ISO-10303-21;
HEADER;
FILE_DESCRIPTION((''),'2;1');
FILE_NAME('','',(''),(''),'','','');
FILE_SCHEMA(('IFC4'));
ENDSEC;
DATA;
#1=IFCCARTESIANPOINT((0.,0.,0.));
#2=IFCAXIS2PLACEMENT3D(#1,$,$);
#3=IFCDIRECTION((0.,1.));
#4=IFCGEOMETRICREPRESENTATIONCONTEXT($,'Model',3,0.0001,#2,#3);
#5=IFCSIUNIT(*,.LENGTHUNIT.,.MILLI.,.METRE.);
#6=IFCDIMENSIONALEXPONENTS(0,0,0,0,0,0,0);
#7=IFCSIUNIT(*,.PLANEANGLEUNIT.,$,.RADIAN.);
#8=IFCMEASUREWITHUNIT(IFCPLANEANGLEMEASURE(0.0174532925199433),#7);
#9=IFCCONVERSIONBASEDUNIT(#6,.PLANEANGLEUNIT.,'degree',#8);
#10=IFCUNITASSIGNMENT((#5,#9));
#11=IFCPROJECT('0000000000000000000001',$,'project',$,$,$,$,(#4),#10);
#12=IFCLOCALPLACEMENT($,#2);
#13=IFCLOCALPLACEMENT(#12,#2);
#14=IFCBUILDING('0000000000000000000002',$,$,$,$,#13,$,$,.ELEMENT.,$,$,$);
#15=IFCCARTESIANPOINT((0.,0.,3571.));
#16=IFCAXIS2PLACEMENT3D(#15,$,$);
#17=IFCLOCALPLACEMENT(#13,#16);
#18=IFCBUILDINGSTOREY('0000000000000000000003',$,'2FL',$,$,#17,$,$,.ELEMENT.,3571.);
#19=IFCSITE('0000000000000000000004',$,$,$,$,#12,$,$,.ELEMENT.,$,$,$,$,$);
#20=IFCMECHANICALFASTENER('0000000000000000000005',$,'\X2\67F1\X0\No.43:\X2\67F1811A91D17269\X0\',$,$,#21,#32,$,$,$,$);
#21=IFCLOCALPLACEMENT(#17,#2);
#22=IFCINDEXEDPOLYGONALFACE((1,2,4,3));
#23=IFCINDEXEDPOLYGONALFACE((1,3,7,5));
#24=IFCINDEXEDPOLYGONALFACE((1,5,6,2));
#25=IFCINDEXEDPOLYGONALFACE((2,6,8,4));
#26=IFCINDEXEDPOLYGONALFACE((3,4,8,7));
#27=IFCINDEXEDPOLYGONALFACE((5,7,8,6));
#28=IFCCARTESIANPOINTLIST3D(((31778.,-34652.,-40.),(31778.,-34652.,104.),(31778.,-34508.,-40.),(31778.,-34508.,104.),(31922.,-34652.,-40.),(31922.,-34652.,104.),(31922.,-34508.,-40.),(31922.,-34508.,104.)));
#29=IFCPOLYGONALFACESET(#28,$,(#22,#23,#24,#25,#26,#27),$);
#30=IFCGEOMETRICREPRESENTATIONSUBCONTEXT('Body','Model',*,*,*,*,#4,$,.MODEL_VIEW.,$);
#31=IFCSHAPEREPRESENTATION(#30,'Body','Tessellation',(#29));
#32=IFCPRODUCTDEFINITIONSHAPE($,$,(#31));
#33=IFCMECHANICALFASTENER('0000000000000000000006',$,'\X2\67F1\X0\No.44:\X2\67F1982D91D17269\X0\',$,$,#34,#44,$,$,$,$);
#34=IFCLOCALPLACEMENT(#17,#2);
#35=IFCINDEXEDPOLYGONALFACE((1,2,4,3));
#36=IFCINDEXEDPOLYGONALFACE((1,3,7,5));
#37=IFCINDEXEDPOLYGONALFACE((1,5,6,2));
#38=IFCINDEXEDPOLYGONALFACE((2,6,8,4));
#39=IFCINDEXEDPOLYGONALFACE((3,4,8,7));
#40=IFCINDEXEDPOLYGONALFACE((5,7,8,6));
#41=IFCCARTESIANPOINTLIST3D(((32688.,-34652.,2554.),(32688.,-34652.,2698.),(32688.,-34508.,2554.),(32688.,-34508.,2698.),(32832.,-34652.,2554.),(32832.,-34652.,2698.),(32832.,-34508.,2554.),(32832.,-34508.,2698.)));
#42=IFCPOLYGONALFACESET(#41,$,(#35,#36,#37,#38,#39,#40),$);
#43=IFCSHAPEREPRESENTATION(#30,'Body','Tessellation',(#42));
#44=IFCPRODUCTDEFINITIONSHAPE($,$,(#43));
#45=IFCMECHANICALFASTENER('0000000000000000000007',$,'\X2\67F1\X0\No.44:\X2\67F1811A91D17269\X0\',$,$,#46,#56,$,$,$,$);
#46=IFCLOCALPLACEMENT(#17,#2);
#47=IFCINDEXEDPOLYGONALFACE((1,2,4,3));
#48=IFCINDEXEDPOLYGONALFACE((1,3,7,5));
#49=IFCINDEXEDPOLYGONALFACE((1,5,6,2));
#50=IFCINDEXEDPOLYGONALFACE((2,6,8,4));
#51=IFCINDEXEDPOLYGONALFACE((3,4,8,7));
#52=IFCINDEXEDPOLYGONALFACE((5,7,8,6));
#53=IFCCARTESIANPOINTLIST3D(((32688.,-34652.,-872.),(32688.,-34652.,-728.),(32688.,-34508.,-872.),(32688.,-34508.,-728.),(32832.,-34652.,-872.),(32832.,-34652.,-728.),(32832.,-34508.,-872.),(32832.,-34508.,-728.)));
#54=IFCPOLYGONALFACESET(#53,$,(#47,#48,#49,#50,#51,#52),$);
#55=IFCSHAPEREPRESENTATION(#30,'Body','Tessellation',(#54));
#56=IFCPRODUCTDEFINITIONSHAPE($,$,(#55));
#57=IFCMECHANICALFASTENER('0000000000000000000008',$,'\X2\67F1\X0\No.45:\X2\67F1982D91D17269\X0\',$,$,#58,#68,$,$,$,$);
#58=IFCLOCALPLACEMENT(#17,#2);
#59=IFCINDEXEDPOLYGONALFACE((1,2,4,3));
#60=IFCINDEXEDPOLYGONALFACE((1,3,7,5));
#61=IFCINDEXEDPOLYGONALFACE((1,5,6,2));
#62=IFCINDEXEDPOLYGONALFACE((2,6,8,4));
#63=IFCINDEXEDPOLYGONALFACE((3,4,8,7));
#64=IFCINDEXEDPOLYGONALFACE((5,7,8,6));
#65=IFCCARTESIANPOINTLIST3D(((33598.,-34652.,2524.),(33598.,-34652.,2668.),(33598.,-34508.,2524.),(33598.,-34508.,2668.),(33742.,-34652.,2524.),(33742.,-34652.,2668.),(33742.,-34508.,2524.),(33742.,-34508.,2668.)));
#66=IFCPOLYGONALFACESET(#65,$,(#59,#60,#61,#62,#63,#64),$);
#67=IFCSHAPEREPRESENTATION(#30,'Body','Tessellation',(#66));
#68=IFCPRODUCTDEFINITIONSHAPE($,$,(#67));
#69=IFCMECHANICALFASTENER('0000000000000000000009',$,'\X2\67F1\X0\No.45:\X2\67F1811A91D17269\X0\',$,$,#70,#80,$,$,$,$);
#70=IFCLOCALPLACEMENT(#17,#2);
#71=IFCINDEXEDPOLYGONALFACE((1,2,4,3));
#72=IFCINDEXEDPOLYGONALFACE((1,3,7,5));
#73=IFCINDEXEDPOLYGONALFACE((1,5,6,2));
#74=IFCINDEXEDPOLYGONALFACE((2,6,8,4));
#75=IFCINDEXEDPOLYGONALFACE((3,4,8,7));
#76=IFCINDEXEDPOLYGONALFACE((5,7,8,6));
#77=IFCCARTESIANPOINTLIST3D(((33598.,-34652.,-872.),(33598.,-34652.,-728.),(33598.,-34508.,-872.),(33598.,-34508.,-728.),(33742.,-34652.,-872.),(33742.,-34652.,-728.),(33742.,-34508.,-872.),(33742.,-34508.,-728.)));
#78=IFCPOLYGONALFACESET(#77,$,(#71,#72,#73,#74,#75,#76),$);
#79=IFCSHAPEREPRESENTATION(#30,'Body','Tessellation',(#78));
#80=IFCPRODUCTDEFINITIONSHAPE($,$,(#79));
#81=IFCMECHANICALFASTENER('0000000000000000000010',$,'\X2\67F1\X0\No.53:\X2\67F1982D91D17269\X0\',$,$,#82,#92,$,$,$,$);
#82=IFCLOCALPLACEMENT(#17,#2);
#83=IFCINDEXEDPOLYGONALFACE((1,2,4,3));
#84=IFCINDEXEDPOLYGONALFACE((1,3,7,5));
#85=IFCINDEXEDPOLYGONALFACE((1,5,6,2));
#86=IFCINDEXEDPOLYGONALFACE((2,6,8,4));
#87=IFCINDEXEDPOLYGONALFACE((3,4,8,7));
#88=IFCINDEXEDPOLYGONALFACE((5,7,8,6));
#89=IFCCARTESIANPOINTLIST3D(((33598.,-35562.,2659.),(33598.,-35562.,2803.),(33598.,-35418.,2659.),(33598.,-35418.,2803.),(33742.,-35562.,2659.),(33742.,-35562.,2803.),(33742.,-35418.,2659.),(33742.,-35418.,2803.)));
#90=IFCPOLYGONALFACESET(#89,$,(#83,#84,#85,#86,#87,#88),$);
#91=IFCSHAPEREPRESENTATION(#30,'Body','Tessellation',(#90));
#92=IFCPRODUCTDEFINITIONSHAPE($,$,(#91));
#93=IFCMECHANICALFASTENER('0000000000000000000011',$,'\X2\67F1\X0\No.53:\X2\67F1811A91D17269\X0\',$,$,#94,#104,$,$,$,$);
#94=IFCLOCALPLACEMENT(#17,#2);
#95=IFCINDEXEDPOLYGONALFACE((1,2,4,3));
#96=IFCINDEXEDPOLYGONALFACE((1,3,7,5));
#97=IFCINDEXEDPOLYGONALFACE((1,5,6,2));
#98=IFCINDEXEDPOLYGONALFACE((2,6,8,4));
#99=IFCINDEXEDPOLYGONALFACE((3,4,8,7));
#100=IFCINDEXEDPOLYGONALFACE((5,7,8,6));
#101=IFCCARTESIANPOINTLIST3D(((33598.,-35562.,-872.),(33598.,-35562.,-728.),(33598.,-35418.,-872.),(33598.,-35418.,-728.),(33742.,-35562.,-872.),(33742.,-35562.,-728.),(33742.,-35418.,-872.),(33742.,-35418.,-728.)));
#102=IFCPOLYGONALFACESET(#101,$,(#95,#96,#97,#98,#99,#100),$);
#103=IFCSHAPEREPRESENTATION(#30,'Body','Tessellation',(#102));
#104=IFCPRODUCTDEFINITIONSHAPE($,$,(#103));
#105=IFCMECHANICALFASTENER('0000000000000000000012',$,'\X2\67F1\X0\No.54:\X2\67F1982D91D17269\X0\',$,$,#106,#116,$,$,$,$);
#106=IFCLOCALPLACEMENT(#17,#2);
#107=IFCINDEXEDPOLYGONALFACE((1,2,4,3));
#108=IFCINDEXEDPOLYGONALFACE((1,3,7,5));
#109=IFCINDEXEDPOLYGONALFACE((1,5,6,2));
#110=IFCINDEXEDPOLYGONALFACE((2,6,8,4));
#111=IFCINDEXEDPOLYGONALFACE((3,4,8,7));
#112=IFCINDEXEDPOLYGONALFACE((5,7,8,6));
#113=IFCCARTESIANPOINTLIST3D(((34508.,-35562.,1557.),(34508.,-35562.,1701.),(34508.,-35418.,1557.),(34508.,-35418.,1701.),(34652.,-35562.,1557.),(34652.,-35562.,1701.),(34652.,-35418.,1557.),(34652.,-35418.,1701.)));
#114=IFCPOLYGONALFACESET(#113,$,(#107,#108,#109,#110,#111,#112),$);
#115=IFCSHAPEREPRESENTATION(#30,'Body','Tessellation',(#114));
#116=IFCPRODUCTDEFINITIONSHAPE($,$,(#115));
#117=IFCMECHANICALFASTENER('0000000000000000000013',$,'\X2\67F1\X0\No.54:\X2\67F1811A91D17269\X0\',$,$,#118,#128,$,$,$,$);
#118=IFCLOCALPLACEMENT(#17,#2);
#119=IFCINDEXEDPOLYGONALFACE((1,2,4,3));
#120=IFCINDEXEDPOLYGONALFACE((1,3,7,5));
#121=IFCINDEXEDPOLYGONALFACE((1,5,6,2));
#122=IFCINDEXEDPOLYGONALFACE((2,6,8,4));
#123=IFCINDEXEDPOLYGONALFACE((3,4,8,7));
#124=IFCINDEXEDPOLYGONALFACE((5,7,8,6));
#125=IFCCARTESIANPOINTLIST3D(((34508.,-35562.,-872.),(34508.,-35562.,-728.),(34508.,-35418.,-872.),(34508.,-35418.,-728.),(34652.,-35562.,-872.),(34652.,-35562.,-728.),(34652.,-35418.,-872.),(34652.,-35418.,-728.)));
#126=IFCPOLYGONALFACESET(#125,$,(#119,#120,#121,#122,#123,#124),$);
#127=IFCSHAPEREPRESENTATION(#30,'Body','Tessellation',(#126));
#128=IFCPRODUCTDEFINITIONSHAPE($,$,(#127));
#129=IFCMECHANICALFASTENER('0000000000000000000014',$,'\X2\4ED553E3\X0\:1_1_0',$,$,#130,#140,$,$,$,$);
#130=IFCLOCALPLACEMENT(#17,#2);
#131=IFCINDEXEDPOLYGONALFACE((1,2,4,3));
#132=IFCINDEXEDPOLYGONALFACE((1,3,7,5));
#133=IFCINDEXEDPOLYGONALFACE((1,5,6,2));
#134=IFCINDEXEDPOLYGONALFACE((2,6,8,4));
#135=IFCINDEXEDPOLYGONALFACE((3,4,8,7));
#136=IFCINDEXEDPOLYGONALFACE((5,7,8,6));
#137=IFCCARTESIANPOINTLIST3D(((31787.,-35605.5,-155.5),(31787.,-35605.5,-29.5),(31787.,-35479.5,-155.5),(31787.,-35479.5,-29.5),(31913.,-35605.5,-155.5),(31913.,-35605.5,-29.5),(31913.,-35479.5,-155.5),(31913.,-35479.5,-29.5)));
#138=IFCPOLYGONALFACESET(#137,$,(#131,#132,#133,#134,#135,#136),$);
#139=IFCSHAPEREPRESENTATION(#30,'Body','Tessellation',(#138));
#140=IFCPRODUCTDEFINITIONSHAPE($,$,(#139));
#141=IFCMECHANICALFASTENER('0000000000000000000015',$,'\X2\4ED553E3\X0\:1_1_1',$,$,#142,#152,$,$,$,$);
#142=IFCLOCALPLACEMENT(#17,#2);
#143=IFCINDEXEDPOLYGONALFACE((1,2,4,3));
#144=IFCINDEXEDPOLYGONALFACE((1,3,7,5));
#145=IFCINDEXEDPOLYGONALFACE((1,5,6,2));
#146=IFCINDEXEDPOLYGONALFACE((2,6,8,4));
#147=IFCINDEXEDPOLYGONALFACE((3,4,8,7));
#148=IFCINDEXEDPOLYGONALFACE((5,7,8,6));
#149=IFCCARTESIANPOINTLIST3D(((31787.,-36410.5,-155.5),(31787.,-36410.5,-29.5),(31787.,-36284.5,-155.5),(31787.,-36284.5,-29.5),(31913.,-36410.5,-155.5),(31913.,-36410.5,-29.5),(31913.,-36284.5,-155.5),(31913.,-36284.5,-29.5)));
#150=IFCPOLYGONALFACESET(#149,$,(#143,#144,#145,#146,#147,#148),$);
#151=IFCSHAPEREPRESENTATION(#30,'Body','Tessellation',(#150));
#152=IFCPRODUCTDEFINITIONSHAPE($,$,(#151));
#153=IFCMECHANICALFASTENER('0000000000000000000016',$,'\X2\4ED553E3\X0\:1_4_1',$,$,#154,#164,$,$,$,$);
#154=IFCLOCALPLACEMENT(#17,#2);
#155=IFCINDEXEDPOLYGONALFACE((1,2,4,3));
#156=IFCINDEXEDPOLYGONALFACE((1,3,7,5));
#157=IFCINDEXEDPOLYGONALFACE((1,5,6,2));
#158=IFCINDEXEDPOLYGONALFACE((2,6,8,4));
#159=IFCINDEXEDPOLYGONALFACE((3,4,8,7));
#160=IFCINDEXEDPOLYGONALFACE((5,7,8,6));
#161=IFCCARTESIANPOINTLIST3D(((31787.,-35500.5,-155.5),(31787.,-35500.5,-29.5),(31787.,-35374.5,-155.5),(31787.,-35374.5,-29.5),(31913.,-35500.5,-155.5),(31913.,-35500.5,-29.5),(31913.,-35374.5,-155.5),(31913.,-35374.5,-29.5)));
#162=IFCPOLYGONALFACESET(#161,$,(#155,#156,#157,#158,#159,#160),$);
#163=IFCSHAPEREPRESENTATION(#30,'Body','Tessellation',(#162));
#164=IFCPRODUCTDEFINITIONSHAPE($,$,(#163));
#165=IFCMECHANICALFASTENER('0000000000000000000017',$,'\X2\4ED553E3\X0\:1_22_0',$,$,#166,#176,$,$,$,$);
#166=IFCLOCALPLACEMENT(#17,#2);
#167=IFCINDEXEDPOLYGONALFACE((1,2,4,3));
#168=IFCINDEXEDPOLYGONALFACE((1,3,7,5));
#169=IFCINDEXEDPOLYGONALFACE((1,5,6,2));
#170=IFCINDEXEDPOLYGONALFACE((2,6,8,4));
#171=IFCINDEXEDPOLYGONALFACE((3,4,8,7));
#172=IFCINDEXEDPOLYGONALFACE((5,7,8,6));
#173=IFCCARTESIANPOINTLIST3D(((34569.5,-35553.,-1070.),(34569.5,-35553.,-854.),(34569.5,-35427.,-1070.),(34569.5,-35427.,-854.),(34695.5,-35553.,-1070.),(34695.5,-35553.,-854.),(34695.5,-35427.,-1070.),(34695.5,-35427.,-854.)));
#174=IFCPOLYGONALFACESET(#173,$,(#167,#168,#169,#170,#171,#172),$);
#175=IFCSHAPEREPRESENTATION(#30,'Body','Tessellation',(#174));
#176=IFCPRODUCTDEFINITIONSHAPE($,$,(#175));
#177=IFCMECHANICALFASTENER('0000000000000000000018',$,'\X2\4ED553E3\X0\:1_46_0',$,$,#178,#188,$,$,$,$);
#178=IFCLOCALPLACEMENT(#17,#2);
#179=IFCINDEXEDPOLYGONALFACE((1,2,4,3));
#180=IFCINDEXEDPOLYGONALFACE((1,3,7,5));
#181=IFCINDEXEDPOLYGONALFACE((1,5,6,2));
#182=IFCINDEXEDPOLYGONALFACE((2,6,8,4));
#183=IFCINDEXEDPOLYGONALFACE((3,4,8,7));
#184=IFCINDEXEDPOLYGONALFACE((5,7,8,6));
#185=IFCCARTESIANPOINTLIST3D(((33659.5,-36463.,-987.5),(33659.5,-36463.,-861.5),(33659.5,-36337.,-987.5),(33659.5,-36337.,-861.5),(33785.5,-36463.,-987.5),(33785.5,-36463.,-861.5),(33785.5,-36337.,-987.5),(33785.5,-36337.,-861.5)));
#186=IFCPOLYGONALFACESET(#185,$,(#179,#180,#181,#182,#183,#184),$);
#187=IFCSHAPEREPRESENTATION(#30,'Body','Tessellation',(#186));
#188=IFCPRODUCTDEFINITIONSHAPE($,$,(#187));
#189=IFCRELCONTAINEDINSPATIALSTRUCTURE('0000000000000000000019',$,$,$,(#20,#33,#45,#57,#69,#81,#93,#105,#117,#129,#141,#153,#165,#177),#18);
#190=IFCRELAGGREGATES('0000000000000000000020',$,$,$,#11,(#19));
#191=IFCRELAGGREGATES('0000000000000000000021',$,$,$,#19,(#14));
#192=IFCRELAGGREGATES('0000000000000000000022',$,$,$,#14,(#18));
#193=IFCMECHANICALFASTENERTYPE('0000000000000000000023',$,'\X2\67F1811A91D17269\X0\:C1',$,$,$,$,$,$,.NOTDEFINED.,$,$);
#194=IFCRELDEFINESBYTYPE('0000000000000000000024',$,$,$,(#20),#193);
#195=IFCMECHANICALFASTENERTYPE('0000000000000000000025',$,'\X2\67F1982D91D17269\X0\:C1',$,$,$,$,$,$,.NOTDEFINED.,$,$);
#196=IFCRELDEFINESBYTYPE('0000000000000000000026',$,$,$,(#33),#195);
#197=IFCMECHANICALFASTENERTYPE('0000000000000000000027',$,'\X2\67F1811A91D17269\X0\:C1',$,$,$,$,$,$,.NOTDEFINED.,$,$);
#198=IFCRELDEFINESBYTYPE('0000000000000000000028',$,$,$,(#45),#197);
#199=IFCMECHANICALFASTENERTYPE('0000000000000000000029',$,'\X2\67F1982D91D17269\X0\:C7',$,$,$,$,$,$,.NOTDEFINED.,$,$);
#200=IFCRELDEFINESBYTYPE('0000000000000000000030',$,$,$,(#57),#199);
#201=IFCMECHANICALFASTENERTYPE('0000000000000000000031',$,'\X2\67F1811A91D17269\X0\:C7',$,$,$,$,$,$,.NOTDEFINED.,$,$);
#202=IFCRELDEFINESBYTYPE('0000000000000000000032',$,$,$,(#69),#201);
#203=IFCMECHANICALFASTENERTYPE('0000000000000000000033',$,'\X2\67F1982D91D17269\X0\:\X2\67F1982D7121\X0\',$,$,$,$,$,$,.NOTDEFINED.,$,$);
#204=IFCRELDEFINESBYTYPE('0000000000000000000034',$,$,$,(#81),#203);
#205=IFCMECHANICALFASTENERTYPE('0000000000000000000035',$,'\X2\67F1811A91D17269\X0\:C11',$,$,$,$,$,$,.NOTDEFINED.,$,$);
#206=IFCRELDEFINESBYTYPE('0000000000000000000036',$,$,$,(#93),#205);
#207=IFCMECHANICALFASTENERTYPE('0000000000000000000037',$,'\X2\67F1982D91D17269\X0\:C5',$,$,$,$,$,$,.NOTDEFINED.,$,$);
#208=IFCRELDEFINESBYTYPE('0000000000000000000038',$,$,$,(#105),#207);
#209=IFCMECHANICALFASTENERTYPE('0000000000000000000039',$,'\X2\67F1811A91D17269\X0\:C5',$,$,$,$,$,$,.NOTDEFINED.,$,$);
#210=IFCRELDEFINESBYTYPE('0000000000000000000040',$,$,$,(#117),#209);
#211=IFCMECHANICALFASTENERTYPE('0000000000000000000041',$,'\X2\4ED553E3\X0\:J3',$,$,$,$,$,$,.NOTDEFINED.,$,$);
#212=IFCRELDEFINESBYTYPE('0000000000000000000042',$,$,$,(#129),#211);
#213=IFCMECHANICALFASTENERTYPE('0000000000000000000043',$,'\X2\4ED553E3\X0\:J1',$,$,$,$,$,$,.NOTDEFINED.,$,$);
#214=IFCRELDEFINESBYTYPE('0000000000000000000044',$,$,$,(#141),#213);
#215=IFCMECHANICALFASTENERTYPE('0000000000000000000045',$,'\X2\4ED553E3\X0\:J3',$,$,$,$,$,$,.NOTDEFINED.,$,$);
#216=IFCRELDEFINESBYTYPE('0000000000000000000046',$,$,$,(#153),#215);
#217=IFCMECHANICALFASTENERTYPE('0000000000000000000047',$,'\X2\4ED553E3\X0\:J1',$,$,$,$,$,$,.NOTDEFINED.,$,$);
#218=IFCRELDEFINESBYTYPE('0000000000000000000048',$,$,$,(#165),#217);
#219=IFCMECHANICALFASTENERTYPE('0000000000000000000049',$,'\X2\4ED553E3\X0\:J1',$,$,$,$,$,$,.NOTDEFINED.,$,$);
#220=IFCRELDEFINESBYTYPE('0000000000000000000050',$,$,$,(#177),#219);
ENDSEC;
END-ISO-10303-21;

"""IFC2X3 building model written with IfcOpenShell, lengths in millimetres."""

from ifc_helpers import new_model, entity, si_unit, converted_unit, direction, frame, origin, origin_with_axes, origin_2d, place, context, subcontext, project, spatial, rectangle, extrude, type_object, element, save


model = new_model("IFC2X3")

# Units and contexts
model_context = context("Model", 3, precision=0.0001, world=origin(), true_north=direction((0.0, 1.0)))
body_context = subcontext(model_context, "Body", "Model", "MODEL_VIEW")
ifc_project = project(units=[si_unit("LENGTHUNIT", "METRE", prefix="MILLI"), converted_unit("PLANEANGLEUNIT", "degree", entity("IfcPlaneAngleMeasure", 0.0174532925199433), si_unit("PLANEANGLEUNIT", "RADIAN"), dimensions=[0, 0, 0, 0, 0, 0, 0])], contexts=[model_context])

# Site, building, storey
site_placement = place(None, origin())
site = spatial("IfcSite", under=ifc_project, at=site_placement, CompositionType="ELEMENT")
building_placement = place(site_placement, origin())
building = spatial("IfcBuilding", under=site, at=building_placement, CompositionType="ELEMENT")
storey_placement = place(building_placement, frame((0.0, 0.0, 3571.0)))
storey = spatial("IfcBuildingStorey", under=building, at=storey_placement, Name="2FL", CompositionType="ELEMENT", Elevation=3571.0)

# Mechanical fasteners
mechanical_fastener_type_1 = type_object("IfcMechanicalFastenerType", Name="柱脚金物:C1")
mechanical_fastener_1_placement = place(storey_placement, frame((31850.0, -34580.0, -40.0)))
element("IfcMechanicalFastener", 1, at=mechanical_fastener_1_placement, inside=storey, type_object=mechanical_fastener_type_1, Name="柱No.43:柱脚金物", context=body_context, shape_type="SweptSolid", body=[
    extrude(rectangle(XDim=144.0, YDim=144.0, at=origin_2d()), origin_with_axes(), (0.0, 0.0, 1.0), 144.0),
])
mechanical_fastener_type_2 = type_object("IfcMechanicalFastenerType", Name="柱頭金物:C1")
mechanical_fastener_2_placement = place(storey_placement, frame((32760.0, -34580.0, 2554.0)))
element("IfcMechanicalFastener", 2, at=mechanical_fastener_2_placement, inside=storey, type_object=mechanical_fastener_type_2, Name="柱No.44:柱頭金物", context=body_context, shape_type="SweptSolid", body=[
    extrude(rectangle(XDim=144.0, YDim=144.0, at=origin_2d()), origin_with_axes(), (0.0, 0.0, 1.0), 144.0),
])
mechanical_fastener_type_3 = type_object("IfcMechanicalFastenerType", Name="柱脚金物:C1")
mechanical_fastener_3_placement = place(storey_placement, frame((32760.0, -34580.0, -872.0)))
element("IfcMechanicalFastener", 3, at=mechanical_fastener_3_placement, inside=storey, type_object=mechanical_fastener_type_3, Name="柱No.44:柱脚金物", context=body_context, shape_type="SweptSolid", body=[
    extrude(rectangle(XDim=144.0, YDim=144.0, at=origin_2d()), origin_with_axes(), (0.0, 0.0, 1.0), 144.0),
])
mechanical_fastener_type_4 = type_object("IfcMechanicalFastenerType", Name="柱頭金物:C7")
mechanical_fastener_4_placement = place(storey_placement, frame((33670.0, -34580.0, 2524.0)))
element("IfcMechanicalFastener", 4, at=mechanical_fastener_4_placement, inside=storey, type_object=mechanical_fastener_type_4, Name="柱No.45:柱頭金物", context=body_context, shape_type="SweptSolid", body=[
    extrude(rectangle(XDim=144.0, YDim=144.0, at=origin_2d()), origin_with_axes(), (0.0, 0.0, 1.0), 144.0),
])
mechanical_fastener_type_5 = type_object("IfcMechanicalFastenerType", Name="柱脚金物:C7")
mechanical_fastener_5_placement = place(storey_placement, frame((33670.0, -34580.0, -872.0)))
element("IfcMechanicalFastener", 5, at=mechanical_fastener_5_placement, inside=storey, type_object=mechanical_fastener_type_5, Name="柱No.45:柱脚金物", context=body_context, shape_type="SweptSolid", body=[
    extrude(rectangle(XDim=144.0, YDim=144.0, at=origin_2d()), origin_with_axes(), (0.0, 0.0, 1.0), 144.0),
])
mechanical_fastener_type_6 = type_object("IfcMechanicalFastenerType", Name="柱頭金物:柱頭無")
mechanical_fastener_6_placement = place(storey_placement, frame((33670.0, -35490.0, 2659.0)))
element("IfcMechanicalFastener", 6, at=mechanical_fastener_6_placement, inside=storey, type_object=mechanical_fastener_type_6, Name="柱No.53:柱頭金物", context=body_context, shape_type="SweptSolid", body=[
    extrude(rectangle(XDim=144.0, YDim=144.0, at=origin_2d()), origin_with_axes(), (0.0, 0.0, 1.0), 144.0),
])
mechanical_fastener_type_7 = type_object("IfcMechanicalFastenerType", Name="柱脚金物:C11")
mechanical_fastener_7_placement = place(storey_placement, frame((33670.0, -35490.0, -872.0)))
element("IfcMechanicalFastener", 7, at=mechanical_fastener_7_placement, inside=storey, type_object=mechanical_fastener_type_7, Name="柱No.53:柱脚金物", context=body_context, shape_type="SweptSolid", body=[
    extrude(rectangle(XDim=144.0, YDim=144.0, at=origin_2d()), origin_with_axes(), (0.0, 0.0, 1.0), 144.0),
])
mechanical_fastener_type_8 = type_object("IfcMechanicalFastenerType", Name="柱頭金物:C5")
mechanical_fastener_8_placement = place(storey_placement, frame((34580.0, -35490.0, 1557.0)))
element("IfcMechanicalFastener", 8, at=mechanical_fastener_8_placement, inside=storey, type_object=mechanical_fastener_type_8, Name="柱No.54:柱頭金物", context=body_context, shape_type="SweptSolid", body=[
    extrude(rectangle(XDim=144.0, YDim=144.0, at=origin_2d()), origin_with_axes(), (0.0, 0.0, 1.0), 144.0),
])
mechanical_fastener_type_9 = type_object("IfcMechanicalFastenerType", Name="柱脚金物:C5")
mechanical_fastener_9_placement = place(storey_placement, frame((34580.0, -35490.0, -872.0)))
element("IfcMechanicalFastener", 9, at=mechanical_fastener_9_placement, inside=storey, type_object=mechanical_fastener_type_9, Name="柱No.54:柱脚金物", context=body_context, shape_type="SweptSolid", body=[
    extrude(rectangle(XDim=144.0, YDim=144.0, at=origin_2d()), origin_with_axes(), (0.0, 0.0, 1.0), 144.0),
])
mechanical_fastener_type_10 = type_object("IfcMechanicalFastenerType", Name="仕口:J3")
mechanical_fastener_10_placement = place(storey_placement, frame((31850.0, -35542.5, -155.5)))
element("IfcMechanicalFastener", 10, at=mechanical_fastener_10_placement, inside=storey, type_object=mechanical_fastener_type_10, Name="仕口:1_1_0", context=body_context, shape_type="SweptSolid", body=[
    extrude(rectangle(XDim=126.0, YDim=126.0, at=origin_2d()), origin_with_axes(), (0.0, 0.0, 1.0), 126.0),
])
mechanical_fastener_type_11 = type_object("IfcMechanicalFastenerType", Name="仕口:J1")
mechanical_fastener_11_placement = place(storey_placement, frame((31850.0, -36347.5, -155.5)))
element("IfcMechanicalFastener", 11, at=mechanical_fastener_11_placement, inside=storey, type_object=mechanical_fastener_type_11, Name="仕口:1_1_1", context=body_context, shape_type="SweptSolid", body=[
    extrude(rectangle(XDim=126.0, YDim=126.0, at=origin_2d()), origin_with_axes(), (0.0, 0.0, 1.0), 126.0),
])
mechanical_fastener_type_12 = type_object("IfcMechanicalFastenerType", Name="仕口:J3")
mechanical_fastener_12_placement = place(storey_placement, frame((31850.0, -35437.5, -155.5)))
element("IfcMechanicalFastener", 12, at=mechanical_fastener_12_placement, inside=storey, type_object=mechanical_fastener_type_12, Name="仕口:1_4_1", context=body_context, shape_type="SweptSolid", body=[
    extrude(rectangle(XDim=126.0, YDim=126.0, at=origin_2d()), origin_with_axes(), (0.0, 0.0, 1.0), 126.0),
])
mechanical_fastener_type_13 = type_object("IfcMechanicalFastenerType", Name="仕口:J1")
mechanical_fastener_13_placement = place(storey_placement, frame((34632.5, -35490.0, -1070.0)))
element("IfcMechanicalFastener", 13, at=mechanical_fastener_13_placement, inside=storey, type_object=mechanical_fastener_type_13, Name="仕口:1_22_0", context=body_context, shape_type="SweptSolid", body=[
    extrude(rectangle(XDim=126.0, YDim=126.0, at=origin_2d()), origin_with_axes(), (0.0, 0.0, 1.0), 216.0),
])
mechanical_fastener_type_14 = type_object("IfcMechanicalFastenerType", Name="仕口:J1")
mechanical_fastener_14_placement = place(storey_placement, frame((33722.5, -36400.0, -987.5)))
element("IfcMechanicalFastener", 14, at=mechanical_fastener_14_placement, inside=storey, type_object=mechanical_fastener_type_14, Name="仕口:1_46_0", context=body_context, shape_type="SweptSolid", body=[
    extrude(rectangle(XDim=126.0, YDim=126.0, at=origin_2d()), origin_with_axes(), (0.0, 0.0, 1.0), 126.0),
])

save(model, "model.ifc")
